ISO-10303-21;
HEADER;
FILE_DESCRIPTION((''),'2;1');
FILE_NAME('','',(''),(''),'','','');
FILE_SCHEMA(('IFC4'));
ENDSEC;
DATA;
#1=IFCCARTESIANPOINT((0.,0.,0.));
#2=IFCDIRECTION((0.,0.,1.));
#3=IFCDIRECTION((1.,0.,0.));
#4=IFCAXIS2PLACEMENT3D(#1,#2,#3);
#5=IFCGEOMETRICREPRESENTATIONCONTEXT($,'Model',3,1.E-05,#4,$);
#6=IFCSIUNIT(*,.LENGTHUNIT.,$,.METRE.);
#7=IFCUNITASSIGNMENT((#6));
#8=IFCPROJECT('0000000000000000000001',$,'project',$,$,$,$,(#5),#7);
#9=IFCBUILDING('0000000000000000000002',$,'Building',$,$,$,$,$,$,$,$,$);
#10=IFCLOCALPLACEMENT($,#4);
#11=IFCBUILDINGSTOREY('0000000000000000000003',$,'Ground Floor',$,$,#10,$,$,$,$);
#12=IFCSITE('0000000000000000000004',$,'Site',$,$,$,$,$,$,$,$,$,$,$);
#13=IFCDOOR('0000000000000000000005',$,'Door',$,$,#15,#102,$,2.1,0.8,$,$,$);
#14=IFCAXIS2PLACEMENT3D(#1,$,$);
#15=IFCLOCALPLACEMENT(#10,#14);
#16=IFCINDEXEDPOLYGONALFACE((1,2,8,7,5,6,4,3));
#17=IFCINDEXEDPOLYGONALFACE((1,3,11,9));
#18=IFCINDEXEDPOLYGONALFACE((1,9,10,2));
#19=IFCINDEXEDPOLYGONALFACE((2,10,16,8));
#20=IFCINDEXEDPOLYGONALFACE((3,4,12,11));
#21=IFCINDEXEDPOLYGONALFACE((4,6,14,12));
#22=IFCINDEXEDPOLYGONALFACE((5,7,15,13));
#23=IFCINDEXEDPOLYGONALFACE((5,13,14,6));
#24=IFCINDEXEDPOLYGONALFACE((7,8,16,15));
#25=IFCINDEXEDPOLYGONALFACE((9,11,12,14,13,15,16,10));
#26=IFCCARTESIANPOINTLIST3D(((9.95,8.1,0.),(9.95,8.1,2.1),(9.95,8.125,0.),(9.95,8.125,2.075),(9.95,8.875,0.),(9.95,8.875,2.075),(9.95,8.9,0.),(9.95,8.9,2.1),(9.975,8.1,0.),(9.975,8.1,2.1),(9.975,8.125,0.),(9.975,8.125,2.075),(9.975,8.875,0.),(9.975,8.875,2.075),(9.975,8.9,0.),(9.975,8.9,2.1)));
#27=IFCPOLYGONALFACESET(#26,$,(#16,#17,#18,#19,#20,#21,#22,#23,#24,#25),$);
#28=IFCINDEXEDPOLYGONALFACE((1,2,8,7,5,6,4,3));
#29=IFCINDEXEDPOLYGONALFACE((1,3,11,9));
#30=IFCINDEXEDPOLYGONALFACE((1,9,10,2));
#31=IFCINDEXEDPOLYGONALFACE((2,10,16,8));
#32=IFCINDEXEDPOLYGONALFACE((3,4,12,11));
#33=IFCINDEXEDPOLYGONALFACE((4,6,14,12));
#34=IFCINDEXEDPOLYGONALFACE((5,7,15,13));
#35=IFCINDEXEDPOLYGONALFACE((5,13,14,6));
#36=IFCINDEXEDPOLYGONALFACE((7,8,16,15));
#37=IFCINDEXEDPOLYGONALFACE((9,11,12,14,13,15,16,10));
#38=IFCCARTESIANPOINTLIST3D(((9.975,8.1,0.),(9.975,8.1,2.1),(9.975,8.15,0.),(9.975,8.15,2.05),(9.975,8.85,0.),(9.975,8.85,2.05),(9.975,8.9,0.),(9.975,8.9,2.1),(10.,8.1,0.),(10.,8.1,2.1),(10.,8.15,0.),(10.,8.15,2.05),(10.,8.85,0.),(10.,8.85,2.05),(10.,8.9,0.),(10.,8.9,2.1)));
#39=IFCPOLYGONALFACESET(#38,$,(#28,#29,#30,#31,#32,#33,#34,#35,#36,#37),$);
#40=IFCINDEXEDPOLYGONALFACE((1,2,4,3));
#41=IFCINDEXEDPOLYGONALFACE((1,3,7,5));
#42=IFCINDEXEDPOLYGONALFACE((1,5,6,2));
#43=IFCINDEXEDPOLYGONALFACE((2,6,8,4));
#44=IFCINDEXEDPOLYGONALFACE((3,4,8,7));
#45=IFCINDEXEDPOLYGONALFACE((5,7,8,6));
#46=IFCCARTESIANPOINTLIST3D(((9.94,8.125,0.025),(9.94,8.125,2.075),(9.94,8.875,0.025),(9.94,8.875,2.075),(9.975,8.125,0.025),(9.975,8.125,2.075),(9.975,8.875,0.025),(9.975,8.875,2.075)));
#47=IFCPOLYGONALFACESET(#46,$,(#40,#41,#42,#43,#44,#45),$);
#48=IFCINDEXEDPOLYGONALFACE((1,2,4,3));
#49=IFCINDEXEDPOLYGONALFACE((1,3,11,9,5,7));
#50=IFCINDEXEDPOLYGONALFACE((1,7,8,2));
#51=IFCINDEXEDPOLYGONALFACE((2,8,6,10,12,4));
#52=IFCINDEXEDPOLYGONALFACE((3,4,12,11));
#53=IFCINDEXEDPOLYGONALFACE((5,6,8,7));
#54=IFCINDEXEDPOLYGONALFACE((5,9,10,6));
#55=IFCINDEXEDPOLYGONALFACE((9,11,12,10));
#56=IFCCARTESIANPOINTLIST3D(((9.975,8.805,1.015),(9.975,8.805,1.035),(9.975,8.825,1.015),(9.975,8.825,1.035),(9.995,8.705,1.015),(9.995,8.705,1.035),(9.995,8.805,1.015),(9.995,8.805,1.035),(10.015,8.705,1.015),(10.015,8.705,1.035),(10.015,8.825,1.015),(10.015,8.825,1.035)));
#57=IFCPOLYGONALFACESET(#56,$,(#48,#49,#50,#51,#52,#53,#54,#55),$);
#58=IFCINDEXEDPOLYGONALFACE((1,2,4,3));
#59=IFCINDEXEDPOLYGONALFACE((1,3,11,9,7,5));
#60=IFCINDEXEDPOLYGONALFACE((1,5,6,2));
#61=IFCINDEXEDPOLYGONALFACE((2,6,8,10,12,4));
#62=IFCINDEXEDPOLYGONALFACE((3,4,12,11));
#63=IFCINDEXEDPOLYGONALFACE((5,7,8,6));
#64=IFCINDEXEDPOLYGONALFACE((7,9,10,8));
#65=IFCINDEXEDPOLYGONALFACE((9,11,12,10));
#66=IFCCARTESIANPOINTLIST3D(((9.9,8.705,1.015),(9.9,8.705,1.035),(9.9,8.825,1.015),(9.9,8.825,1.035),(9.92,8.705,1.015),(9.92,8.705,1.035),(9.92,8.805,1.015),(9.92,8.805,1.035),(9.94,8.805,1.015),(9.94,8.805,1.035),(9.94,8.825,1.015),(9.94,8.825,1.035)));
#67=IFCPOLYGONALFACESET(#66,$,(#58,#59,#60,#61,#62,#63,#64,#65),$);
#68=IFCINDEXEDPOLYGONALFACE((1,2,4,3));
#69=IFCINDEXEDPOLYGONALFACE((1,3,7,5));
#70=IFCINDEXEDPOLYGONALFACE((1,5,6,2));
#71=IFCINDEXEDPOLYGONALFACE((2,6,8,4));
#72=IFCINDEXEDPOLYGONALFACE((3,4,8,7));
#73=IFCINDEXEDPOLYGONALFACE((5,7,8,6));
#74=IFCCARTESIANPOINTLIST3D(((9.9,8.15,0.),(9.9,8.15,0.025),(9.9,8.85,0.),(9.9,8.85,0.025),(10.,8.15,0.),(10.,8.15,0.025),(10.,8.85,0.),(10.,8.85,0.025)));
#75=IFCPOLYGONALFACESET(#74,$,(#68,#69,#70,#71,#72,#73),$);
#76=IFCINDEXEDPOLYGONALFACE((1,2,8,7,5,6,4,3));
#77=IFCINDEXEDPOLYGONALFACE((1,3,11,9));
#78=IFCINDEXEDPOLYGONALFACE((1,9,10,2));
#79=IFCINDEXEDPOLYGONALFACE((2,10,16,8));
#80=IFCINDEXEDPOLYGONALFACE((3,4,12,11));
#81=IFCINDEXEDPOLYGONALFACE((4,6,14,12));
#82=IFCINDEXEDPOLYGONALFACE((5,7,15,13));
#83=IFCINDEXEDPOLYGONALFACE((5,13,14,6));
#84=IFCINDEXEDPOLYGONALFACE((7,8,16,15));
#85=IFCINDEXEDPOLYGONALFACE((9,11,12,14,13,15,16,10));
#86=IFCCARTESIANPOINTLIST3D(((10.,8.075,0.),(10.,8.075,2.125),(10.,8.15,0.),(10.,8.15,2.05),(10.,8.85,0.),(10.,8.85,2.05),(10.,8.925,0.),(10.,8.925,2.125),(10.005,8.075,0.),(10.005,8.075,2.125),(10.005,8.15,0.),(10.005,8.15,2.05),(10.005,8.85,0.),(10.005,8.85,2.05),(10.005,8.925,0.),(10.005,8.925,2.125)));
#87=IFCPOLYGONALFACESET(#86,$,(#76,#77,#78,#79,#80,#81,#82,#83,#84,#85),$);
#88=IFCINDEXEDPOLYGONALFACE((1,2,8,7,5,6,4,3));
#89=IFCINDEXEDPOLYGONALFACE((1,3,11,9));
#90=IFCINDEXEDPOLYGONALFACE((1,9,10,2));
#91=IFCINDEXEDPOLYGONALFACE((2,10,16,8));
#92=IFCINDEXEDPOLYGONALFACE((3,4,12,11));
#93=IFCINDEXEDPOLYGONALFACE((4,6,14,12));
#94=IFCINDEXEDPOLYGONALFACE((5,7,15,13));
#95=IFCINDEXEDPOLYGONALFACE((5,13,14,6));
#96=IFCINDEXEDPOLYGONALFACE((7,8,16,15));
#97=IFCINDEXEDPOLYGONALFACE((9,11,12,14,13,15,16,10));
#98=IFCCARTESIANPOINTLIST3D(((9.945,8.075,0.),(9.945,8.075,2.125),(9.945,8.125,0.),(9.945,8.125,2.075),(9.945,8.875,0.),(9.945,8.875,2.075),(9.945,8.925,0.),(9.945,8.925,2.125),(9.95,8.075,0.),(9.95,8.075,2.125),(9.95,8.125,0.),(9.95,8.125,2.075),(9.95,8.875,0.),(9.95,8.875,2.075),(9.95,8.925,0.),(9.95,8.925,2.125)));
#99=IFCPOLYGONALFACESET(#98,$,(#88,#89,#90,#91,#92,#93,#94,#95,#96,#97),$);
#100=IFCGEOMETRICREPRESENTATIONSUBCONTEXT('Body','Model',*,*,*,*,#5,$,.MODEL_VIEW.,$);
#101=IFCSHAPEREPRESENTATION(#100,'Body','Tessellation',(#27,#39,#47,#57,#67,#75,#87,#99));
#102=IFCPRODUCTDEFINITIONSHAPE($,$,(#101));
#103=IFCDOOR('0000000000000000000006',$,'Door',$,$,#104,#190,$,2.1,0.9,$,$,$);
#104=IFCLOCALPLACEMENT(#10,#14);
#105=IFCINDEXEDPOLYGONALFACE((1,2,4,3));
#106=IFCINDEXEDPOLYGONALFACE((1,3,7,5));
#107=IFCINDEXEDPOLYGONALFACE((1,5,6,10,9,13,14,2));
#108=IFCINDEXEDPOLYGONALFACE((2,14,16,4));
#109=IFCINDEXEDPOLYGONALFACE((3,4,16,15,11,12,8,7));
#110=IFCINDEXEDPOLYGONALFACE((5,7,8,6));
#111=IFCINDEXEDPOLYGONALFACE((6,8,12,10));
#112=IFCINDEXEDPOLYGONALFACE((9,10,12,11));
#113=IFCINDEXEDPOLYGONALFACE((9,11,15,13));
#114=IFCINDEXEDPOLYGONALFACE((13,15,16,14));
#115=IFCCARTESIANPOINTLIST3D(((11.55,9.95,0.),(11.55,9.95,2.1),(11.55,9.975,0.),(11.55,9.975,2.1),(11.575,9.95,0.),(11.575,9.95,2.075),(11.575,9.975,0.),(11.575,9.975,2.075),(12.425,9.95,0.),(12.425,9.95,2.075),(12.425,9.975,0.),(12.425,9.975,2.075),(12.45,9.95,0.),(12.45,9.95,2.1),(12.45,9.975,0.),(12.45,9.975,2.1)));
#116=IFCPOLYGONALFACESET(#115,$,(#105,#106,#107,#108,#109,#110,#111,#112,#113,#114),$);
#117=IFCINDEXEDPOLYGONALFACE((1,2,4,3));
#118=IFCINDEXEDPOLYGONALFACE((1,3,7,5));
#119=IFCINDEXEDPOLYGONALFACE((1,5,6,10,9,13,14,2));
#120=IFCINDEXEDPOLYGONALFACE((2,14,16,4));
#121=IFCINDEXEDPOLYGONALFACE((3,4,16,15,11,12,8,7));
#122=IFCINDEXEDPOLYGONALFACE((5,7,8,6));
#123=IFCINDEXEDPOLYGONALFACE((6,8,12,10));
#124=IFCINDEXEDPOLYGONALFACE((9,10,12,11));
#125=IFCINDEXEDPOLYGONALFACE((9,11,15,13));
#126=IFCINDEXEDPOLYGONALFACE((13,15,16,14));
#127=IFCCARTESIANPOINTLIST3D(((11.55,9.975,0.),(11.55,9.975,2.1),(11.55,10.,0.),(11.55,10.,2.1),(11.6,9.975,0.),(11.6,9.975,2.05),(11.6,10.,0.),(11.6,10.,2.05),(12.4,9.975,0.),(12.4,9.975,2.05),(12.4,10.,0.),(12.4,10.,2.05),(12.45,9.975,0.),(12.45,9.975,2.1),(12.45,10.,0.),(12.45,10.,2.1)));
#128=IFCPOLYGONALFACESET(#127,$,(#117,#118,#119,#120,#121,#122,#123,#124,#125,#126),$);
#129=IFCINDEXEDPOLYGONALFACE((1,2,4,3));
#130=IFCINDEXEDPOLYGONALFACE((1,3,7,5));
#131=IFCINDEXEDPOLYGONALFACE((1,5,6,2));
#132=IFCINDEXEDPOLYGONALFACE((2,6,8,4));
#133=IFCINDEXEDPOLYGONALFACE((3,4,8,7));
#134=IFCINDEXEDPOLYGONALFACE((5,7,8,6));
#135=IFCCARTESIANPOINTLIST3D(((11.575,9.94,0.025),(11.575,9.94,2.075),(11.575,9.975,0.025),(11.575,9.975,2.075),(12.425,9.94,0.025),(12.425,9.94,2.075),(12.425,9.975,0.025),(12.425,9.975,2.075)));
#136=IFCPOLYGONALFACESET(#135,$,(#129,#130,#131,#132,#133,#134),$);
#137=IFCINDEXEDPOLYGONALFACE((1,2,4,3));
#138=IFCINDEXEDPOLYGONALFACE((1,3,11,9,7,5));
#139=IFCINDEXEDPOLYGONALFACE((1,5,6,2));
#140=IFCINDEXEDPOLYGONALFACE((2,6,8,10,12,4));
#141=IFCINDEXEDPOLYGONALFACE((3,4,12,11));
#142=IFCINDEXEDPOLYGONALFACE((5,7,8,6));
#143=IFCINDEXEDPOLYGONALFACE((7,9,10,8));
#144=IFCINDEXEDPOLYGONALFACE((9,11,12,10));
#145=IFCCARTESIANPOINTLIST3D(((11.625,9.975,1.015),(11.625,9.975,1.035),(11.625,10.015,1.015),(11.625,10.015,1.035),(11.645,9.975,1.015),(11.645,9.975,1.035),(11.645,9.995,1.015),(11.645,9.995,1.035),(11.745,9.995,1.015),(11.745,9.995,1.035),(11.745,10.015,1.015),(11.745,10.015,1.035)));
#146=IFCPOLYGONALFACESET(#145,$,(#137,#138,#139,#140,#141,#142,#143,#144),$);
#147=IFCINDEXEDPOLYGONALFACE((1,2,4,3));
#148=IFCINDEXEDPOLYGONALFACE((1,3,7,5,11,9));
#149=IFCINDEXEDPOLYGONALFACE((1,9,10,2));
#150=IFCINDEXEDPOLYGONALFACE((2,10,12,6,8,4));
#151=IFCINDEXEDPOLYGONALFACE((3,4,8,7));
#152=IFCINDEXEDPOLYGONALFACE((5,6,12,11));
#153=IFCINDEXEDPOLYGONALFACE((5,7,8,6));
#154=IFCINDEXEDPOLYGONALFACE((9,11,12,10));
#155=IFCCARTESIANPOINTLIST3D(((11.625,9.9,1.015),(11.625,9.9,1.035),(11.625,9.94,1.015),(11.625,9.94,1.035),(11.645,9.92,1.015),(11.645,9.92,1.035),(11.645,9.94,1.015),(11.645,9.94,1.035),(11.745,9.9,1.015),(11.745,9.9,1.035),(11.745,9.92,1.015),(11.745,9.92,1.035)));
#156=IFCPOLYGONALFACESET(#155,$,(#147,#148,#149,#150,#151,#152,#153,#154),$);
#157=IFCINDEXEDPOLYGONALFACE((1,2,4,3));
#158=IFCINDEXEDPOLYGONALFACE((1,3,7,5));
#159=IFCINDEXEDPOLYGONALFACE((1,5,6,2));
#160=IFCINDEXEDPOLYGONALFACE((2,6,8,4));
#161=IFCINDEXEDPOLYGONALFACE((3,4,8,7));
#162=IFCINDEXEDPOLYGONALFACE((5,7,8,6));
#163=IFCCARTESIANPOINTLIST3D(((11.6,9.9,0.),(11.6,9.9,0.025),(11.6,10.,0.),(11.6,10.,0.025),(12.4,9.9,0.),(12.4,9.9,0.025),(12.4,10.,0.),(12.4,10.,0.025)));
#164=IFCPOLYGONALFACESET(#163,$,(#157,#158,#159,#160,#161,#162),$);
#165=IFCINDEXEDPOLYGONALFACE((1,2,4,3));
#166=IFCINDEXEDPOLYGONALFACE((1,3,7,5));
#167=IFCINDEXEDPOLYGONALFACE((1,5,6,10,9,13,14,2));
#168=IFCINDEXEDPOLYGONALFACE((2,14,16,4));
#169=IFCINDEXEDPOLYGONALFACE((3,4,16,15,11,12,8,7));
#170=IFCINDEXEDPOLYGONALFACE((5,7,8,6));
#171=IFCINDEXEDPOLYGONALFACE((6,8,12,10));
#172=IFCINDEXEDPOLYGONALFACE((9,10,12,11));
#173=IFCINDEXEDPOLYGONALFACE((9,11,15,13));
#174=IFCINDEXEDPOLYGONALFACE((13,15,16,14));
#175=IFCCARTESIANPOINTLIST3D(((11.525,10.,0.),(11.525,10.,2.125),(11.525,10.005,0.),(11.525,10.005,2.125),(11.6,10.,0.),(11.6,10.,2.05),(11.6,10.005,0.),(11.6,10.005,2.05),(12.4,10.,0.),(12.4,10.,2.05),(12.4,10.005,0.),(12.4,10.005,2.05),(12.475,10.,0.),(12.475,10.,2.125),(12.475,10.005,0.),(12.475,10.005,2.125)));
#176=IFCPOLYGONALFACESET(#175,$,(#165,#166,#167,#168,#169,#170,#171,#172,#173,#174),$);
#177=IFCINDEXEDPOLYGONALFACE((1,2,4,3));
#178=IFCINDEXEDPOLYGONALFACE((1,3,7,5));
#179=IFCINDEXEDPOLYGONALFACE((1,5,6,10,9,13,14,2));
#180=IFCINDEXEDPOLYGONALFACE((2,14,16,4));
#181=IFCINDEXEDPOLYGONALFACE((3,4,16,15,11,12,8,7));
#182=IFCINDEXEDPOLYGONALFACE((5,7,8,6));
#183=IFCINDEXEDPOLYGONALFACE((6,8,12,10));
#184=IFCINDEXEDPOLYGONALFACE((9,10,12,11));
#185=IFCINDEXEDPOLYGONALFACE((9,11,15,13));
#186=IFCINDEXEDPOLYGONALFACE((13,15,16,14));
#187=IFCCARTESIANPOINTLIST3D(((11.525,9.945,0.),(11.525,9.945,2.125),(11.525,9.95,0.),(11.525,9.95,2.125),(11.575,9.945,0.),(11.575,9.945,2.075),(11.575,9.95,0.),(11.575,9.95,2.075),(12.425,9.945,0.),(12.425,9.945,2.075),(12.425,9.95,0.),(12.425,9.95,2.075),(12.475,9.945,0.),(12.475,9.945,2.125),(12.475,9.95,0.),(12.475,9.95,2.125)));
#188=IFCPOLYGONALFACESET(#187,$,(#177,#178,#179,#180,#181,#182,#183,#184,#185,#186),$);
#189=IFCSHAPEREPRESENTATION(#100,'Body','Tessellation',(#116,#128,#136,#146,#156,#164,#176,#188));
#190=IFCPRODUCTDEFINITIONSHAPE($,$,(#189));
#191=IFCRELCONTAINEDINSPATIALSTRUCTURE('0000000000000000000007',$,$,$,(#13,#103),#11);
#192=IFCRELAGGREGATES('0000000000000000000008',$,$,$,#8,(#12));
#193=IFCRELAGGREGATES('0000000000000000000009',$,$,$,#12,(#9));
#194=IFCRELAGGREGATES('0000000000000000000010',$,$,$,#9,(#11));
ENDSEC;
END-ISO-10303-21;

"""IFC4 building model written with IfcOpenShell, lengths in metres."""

from ifc_helpers import new_model, si_unit, frame, origin_with_axes, place, context, subcontext, project, spatial, line, indexed_curve, outline, extrude, element, save


model = new_model("IFC4")

# Units and contexts
model_context = context("Model", 3, precision=1e-05, world=origin_with_axes())
body_context = subcontext(model_context, "Body", "Model", "MODEL_VIEW")
ifc_project = project(units=[si_unit("LENGTHUNIT", "METRE")], contexts=[model_context])

# Site, building, storey
site = spatial("IfcSite", under=ifc_project, Name="Site")
building = spatial("IfcBuilding", under=site, Name="Building")
storey_placement = place(None, origin_with_axes())
storey = spatial("IfcBuildingStorey", under=building, at=storey_placement, Name="Ground Floor")

# Doors
door_1_placement = place(storey_placement, frame((10.0, 8.1, 0.0), z_axis=(0.0, 0.0, 1.0), x_axis=(0.0, 1.0, 0.0)))
element("IfcDoor", 1, at=door_1_placement, inside=storey, Name="Door", OverallHeight=2.1, OverallWidth=0.8, context=body_context, shape_type="SweptSolid", body=[
    extrude(outline(indexed_curve([(0.0, 0.0), (0.0, 2.1), (0.8, 2.1), (0.8, 0.0), (0.775, 0.0), (0.775, 2.075), (0.025, 2.075), (0.025, 0.0)], segments=[line(1, 2, 3, 4, 5, 6, 7, 8, 1)])), frame((0.0, 0.025, 0.0), z_axis=(0.0, -1.0, 0.0), x_axis=(1.0, 0.0, 0.0)), (0.0, 0.0, -1.0), 0.025),
    extrude(outline(indexed_curve([(0.0, 0.0), (0.0, 2.1), (0.8, 2.1), (0.8, 0.0), (0.75, 0.0), (0.75, 2.05), (0.05, 2.05), (0.05, 0.0)], segments=[line(1, 2, 3, 4, 5, 6, 7, 8, 1)])), frame((0.0, 0.0, 0.0), z_axis=(0.0, -1.0, 0.0), x_axis=(1.0, 0.0, 0.0)), (0.0, 0.0, -1.0), 0.025),
    extrude(outline(indexed_curve([(0.0, 0.0), (0.75, 0.0), (0.75, 0.035), (0.0, 0.035)], segments=[line(1, 2, 3, 4, 1)])), frame((0.025, 0.025, 0.025), z_axis=(0.0, 0.0, 1.0), x_axis=(1.0, 0.0, 0.0)), (0.0, 0.0, 1.0), 2.05),
    extrude(outline(indexed_curve([(0.0, 0.0), (0.0, -0.04), (-0.12, -0.04), (-0.12, -0.02), (-0.02, -0.02), (-0.02, 0.0)], segments=[line(1, 2, 3, 4, 5, 6, 1)])), frame((0.725, 0.025, 1.015), z_axis=(0.0, 0.0, 1.0), x_axis=(1.0, 0.0, 0.0)), (0.0, 0.0, 1.0), 0.02),
    extrude(outline(indexed_curve([(0.0, 0.0), (0.0, 0.04), (-0.12, 0.04), (-0.12, 0.02), (-0.02, 0.02), (-0.02, 0.0)], segments=[line(1, 2, 3, 4, 5, 6, 1)])), frame((0.725, 0.06, 1.015), z_axis=(0.0, 0.0, 1.0), x_axis=(1.0, 0.0, 0.0)), (0.0, 0.0, 1.0), 0.02),
    extrude(outline(indexed_curve([(0.0, 0.0), (0.7, 0.0), (0.7, 0.1), (0.0, 0.1)], segments=[line(1, 2, 3, 4, 1)])), frame((0.05, 0.0, 0.0), z_axis=(0.0, 0.0, 1.0), x_axis=(1.0, 0.0, 0.0)), (0.0, 0.0, 1.0), 0.025),
    extrude(outline(indexed_curve([(0.0, 0.0), (0.0, 2.125), (0.85, 2.125), (0.85, 0.0), (0.775, 0.0), (0.775, 2.05), (0.075, 2.05), (0.075, 0.0)], segments=[line(1, 2, 3, 4, 5, 6, 7, 8, 1)])), frame((-0.025, -0.005, 0.0), z_axis=(0.0, -1.0, 0.0), x_axis=(1.0, 0.0, 0.0)), (0.0, 0.0, -1.0), 0.005),
    extrude(outline(indexed_curve([(0.0, 0.0), (0.0, 2.125), (0.85, 2.125), (0.85, 0.0), (0.8, 0.0), (0.8, 2.075), (0.05, 2.075), (0.05, 0.0)], segments=[line(1, 2, 3, 4, 5, 6, 7, 8, 1)])), frame((-0.025, 0.05, 0.0), z_axis=(0.0, -1.0, 0.0), x_axis=(1.0, 0.0, 0.0)), (0.0, 0.0, -1.0), 0.005),
])
door_2_placement = place(storey_placement, frame((12.45, 10.0, 0.0), z_axis=(0.0, 0.0, 1.0), x_axis=(-1.0, 0.0, 0.0)))
element("IfcDoor", 2, at=door_2_placement, inside=storey, Name="Door", OverallHeight=2.1, OverallWidth=0.9, context=body_context, shape_type="SweptSolid", body=[
    extrude(outline(indexed_curve([(0.0, 0.0), (0.0, 2.1), (0.9, 2.1), (0.9, 0.0), (0.875, 0.0), (0.875, 2.075), (0.025, 2.075), (0.025, 0.0)], segments=[line(1, 2, 3, 4, 5, 6, 7, 8, 1)])), frame((0.0, 0.025, 0.0), z_axis=(0.0, -1.0, 0.0), x_axis=(1.0, 0.0, 0.0)), (0.0, 0.0, -1.0), 0.025),
    extrude(outline(indexed_curve([(0.0, 0.0), (0.0, 2.1), (0.9, 2.1), (0.9, 0.0), (0.85, 0.0), (0.85, 2.05), (0.05, 2.05), (0.05, 0.0)], segments=[line(1, 2, 3, 4, 5, 6, 7, 8, 1)])), frame((0.0, 0.0, 0.0), z_axis=(0.0, -1.0, 0.0), x_axis=(1.0, 0.0, 0.0)), (0.0, 0.0, -1.0), 0.025),
    extrude(outline(indexed_curve([(0.0, 0.0), (0.85, 0.0), (0.85, 0.035), (0.0, 0.035)], segments=[line(1, 2, 3, 4, 1)])), frame((0.025, 0.025, 0.025), z_axis=(0.0, 0.0, 1.0), x_axis=(1.0, 0.0, 0.0)), (0.0, 0.0, 1.0), 2.05),
    extrude(outline(indexed_curve([(0.0, 0.0), (0.0, -0.04), (-0.12, -0.04), (-0.12, -0.02), (-0.02, -0.02), (-0.02, 0.0)], segments=[line(1, 2, 3, 4, 5, 6, 1)])), frame((0.825, 0.025, 1.015), z_axis=(0.0, 0.0, 1.0), x_axis=(1.0, 0.0, 0.0)), (0.0, 0.0, 1.0), 0.02),
    extrude(outline(indexed_curve([(0.0, 0.0), (0.0, 0.04), (-0.12, 0.04), (-0.12, 0.02), (-0.02, 0.02), (-0.02, 0.0)], segments=[line(1, 2, 3, 4, 5, 6, 1)])), frame((0.825, 0.06, 1.015), z_axis=(0.0, 0.0, 1.0), x_axis=(1.0, 0.0, 0.0)), (0.0, 0.0, 1.0), 0.02),
    extrude(outline(indexed_curve([(0.0, 0.0), (0.8, 0.0), (0.8, 0.1), (0.0, 0.1)], segments=[line(1, 2, 3, 4, 1)])), frame((0.05, 0.0, 0.0), z_axis=(0.0, 0.0, 1.0), x_axis=(1.0, 0.0, 0.0)), (0.0, 0.0, 1.0), 0.025),
    extrude(outline(indexed_curve([(0.0, 0.0), (0.0, 2.125), (0.95, 2.125), (0.95, 0.0), (0.875, 0.0), (0.875, 2.05), (0.075, 2.05), (0.075, 0.0)], segments=[line(1, 2, 3, 4, 5, 6, 7, 8, 1)])), frame((-0.025, -0.005, 0.0), z_axis=(0.0, -1.0, 0.0), x_axis=(1.0, 0.0, 0.0)), (0.0, 0.0, -1.0), 0.005),
    extrude(outline(indexed_curve([(0.0, 0.0), (0.0, 2.125), (0.95, 2.125), (0.95, 0.0), (0.9, 0.0), (0.9, 2.075), (0.05, 2.075), (0.05, 0.0)], segments=[line(1, 2, 3, 4, 5, 6, 7, 8, 1)])), frame((-0.025, 0.05, 0.0), z_axis=(0.0, -1.0, 0.0), x_axis=(1.0, 0.0, 0.0)), (0.0, 0.0, -1.0), 0.005),
])

save(model, "model.ifc")
